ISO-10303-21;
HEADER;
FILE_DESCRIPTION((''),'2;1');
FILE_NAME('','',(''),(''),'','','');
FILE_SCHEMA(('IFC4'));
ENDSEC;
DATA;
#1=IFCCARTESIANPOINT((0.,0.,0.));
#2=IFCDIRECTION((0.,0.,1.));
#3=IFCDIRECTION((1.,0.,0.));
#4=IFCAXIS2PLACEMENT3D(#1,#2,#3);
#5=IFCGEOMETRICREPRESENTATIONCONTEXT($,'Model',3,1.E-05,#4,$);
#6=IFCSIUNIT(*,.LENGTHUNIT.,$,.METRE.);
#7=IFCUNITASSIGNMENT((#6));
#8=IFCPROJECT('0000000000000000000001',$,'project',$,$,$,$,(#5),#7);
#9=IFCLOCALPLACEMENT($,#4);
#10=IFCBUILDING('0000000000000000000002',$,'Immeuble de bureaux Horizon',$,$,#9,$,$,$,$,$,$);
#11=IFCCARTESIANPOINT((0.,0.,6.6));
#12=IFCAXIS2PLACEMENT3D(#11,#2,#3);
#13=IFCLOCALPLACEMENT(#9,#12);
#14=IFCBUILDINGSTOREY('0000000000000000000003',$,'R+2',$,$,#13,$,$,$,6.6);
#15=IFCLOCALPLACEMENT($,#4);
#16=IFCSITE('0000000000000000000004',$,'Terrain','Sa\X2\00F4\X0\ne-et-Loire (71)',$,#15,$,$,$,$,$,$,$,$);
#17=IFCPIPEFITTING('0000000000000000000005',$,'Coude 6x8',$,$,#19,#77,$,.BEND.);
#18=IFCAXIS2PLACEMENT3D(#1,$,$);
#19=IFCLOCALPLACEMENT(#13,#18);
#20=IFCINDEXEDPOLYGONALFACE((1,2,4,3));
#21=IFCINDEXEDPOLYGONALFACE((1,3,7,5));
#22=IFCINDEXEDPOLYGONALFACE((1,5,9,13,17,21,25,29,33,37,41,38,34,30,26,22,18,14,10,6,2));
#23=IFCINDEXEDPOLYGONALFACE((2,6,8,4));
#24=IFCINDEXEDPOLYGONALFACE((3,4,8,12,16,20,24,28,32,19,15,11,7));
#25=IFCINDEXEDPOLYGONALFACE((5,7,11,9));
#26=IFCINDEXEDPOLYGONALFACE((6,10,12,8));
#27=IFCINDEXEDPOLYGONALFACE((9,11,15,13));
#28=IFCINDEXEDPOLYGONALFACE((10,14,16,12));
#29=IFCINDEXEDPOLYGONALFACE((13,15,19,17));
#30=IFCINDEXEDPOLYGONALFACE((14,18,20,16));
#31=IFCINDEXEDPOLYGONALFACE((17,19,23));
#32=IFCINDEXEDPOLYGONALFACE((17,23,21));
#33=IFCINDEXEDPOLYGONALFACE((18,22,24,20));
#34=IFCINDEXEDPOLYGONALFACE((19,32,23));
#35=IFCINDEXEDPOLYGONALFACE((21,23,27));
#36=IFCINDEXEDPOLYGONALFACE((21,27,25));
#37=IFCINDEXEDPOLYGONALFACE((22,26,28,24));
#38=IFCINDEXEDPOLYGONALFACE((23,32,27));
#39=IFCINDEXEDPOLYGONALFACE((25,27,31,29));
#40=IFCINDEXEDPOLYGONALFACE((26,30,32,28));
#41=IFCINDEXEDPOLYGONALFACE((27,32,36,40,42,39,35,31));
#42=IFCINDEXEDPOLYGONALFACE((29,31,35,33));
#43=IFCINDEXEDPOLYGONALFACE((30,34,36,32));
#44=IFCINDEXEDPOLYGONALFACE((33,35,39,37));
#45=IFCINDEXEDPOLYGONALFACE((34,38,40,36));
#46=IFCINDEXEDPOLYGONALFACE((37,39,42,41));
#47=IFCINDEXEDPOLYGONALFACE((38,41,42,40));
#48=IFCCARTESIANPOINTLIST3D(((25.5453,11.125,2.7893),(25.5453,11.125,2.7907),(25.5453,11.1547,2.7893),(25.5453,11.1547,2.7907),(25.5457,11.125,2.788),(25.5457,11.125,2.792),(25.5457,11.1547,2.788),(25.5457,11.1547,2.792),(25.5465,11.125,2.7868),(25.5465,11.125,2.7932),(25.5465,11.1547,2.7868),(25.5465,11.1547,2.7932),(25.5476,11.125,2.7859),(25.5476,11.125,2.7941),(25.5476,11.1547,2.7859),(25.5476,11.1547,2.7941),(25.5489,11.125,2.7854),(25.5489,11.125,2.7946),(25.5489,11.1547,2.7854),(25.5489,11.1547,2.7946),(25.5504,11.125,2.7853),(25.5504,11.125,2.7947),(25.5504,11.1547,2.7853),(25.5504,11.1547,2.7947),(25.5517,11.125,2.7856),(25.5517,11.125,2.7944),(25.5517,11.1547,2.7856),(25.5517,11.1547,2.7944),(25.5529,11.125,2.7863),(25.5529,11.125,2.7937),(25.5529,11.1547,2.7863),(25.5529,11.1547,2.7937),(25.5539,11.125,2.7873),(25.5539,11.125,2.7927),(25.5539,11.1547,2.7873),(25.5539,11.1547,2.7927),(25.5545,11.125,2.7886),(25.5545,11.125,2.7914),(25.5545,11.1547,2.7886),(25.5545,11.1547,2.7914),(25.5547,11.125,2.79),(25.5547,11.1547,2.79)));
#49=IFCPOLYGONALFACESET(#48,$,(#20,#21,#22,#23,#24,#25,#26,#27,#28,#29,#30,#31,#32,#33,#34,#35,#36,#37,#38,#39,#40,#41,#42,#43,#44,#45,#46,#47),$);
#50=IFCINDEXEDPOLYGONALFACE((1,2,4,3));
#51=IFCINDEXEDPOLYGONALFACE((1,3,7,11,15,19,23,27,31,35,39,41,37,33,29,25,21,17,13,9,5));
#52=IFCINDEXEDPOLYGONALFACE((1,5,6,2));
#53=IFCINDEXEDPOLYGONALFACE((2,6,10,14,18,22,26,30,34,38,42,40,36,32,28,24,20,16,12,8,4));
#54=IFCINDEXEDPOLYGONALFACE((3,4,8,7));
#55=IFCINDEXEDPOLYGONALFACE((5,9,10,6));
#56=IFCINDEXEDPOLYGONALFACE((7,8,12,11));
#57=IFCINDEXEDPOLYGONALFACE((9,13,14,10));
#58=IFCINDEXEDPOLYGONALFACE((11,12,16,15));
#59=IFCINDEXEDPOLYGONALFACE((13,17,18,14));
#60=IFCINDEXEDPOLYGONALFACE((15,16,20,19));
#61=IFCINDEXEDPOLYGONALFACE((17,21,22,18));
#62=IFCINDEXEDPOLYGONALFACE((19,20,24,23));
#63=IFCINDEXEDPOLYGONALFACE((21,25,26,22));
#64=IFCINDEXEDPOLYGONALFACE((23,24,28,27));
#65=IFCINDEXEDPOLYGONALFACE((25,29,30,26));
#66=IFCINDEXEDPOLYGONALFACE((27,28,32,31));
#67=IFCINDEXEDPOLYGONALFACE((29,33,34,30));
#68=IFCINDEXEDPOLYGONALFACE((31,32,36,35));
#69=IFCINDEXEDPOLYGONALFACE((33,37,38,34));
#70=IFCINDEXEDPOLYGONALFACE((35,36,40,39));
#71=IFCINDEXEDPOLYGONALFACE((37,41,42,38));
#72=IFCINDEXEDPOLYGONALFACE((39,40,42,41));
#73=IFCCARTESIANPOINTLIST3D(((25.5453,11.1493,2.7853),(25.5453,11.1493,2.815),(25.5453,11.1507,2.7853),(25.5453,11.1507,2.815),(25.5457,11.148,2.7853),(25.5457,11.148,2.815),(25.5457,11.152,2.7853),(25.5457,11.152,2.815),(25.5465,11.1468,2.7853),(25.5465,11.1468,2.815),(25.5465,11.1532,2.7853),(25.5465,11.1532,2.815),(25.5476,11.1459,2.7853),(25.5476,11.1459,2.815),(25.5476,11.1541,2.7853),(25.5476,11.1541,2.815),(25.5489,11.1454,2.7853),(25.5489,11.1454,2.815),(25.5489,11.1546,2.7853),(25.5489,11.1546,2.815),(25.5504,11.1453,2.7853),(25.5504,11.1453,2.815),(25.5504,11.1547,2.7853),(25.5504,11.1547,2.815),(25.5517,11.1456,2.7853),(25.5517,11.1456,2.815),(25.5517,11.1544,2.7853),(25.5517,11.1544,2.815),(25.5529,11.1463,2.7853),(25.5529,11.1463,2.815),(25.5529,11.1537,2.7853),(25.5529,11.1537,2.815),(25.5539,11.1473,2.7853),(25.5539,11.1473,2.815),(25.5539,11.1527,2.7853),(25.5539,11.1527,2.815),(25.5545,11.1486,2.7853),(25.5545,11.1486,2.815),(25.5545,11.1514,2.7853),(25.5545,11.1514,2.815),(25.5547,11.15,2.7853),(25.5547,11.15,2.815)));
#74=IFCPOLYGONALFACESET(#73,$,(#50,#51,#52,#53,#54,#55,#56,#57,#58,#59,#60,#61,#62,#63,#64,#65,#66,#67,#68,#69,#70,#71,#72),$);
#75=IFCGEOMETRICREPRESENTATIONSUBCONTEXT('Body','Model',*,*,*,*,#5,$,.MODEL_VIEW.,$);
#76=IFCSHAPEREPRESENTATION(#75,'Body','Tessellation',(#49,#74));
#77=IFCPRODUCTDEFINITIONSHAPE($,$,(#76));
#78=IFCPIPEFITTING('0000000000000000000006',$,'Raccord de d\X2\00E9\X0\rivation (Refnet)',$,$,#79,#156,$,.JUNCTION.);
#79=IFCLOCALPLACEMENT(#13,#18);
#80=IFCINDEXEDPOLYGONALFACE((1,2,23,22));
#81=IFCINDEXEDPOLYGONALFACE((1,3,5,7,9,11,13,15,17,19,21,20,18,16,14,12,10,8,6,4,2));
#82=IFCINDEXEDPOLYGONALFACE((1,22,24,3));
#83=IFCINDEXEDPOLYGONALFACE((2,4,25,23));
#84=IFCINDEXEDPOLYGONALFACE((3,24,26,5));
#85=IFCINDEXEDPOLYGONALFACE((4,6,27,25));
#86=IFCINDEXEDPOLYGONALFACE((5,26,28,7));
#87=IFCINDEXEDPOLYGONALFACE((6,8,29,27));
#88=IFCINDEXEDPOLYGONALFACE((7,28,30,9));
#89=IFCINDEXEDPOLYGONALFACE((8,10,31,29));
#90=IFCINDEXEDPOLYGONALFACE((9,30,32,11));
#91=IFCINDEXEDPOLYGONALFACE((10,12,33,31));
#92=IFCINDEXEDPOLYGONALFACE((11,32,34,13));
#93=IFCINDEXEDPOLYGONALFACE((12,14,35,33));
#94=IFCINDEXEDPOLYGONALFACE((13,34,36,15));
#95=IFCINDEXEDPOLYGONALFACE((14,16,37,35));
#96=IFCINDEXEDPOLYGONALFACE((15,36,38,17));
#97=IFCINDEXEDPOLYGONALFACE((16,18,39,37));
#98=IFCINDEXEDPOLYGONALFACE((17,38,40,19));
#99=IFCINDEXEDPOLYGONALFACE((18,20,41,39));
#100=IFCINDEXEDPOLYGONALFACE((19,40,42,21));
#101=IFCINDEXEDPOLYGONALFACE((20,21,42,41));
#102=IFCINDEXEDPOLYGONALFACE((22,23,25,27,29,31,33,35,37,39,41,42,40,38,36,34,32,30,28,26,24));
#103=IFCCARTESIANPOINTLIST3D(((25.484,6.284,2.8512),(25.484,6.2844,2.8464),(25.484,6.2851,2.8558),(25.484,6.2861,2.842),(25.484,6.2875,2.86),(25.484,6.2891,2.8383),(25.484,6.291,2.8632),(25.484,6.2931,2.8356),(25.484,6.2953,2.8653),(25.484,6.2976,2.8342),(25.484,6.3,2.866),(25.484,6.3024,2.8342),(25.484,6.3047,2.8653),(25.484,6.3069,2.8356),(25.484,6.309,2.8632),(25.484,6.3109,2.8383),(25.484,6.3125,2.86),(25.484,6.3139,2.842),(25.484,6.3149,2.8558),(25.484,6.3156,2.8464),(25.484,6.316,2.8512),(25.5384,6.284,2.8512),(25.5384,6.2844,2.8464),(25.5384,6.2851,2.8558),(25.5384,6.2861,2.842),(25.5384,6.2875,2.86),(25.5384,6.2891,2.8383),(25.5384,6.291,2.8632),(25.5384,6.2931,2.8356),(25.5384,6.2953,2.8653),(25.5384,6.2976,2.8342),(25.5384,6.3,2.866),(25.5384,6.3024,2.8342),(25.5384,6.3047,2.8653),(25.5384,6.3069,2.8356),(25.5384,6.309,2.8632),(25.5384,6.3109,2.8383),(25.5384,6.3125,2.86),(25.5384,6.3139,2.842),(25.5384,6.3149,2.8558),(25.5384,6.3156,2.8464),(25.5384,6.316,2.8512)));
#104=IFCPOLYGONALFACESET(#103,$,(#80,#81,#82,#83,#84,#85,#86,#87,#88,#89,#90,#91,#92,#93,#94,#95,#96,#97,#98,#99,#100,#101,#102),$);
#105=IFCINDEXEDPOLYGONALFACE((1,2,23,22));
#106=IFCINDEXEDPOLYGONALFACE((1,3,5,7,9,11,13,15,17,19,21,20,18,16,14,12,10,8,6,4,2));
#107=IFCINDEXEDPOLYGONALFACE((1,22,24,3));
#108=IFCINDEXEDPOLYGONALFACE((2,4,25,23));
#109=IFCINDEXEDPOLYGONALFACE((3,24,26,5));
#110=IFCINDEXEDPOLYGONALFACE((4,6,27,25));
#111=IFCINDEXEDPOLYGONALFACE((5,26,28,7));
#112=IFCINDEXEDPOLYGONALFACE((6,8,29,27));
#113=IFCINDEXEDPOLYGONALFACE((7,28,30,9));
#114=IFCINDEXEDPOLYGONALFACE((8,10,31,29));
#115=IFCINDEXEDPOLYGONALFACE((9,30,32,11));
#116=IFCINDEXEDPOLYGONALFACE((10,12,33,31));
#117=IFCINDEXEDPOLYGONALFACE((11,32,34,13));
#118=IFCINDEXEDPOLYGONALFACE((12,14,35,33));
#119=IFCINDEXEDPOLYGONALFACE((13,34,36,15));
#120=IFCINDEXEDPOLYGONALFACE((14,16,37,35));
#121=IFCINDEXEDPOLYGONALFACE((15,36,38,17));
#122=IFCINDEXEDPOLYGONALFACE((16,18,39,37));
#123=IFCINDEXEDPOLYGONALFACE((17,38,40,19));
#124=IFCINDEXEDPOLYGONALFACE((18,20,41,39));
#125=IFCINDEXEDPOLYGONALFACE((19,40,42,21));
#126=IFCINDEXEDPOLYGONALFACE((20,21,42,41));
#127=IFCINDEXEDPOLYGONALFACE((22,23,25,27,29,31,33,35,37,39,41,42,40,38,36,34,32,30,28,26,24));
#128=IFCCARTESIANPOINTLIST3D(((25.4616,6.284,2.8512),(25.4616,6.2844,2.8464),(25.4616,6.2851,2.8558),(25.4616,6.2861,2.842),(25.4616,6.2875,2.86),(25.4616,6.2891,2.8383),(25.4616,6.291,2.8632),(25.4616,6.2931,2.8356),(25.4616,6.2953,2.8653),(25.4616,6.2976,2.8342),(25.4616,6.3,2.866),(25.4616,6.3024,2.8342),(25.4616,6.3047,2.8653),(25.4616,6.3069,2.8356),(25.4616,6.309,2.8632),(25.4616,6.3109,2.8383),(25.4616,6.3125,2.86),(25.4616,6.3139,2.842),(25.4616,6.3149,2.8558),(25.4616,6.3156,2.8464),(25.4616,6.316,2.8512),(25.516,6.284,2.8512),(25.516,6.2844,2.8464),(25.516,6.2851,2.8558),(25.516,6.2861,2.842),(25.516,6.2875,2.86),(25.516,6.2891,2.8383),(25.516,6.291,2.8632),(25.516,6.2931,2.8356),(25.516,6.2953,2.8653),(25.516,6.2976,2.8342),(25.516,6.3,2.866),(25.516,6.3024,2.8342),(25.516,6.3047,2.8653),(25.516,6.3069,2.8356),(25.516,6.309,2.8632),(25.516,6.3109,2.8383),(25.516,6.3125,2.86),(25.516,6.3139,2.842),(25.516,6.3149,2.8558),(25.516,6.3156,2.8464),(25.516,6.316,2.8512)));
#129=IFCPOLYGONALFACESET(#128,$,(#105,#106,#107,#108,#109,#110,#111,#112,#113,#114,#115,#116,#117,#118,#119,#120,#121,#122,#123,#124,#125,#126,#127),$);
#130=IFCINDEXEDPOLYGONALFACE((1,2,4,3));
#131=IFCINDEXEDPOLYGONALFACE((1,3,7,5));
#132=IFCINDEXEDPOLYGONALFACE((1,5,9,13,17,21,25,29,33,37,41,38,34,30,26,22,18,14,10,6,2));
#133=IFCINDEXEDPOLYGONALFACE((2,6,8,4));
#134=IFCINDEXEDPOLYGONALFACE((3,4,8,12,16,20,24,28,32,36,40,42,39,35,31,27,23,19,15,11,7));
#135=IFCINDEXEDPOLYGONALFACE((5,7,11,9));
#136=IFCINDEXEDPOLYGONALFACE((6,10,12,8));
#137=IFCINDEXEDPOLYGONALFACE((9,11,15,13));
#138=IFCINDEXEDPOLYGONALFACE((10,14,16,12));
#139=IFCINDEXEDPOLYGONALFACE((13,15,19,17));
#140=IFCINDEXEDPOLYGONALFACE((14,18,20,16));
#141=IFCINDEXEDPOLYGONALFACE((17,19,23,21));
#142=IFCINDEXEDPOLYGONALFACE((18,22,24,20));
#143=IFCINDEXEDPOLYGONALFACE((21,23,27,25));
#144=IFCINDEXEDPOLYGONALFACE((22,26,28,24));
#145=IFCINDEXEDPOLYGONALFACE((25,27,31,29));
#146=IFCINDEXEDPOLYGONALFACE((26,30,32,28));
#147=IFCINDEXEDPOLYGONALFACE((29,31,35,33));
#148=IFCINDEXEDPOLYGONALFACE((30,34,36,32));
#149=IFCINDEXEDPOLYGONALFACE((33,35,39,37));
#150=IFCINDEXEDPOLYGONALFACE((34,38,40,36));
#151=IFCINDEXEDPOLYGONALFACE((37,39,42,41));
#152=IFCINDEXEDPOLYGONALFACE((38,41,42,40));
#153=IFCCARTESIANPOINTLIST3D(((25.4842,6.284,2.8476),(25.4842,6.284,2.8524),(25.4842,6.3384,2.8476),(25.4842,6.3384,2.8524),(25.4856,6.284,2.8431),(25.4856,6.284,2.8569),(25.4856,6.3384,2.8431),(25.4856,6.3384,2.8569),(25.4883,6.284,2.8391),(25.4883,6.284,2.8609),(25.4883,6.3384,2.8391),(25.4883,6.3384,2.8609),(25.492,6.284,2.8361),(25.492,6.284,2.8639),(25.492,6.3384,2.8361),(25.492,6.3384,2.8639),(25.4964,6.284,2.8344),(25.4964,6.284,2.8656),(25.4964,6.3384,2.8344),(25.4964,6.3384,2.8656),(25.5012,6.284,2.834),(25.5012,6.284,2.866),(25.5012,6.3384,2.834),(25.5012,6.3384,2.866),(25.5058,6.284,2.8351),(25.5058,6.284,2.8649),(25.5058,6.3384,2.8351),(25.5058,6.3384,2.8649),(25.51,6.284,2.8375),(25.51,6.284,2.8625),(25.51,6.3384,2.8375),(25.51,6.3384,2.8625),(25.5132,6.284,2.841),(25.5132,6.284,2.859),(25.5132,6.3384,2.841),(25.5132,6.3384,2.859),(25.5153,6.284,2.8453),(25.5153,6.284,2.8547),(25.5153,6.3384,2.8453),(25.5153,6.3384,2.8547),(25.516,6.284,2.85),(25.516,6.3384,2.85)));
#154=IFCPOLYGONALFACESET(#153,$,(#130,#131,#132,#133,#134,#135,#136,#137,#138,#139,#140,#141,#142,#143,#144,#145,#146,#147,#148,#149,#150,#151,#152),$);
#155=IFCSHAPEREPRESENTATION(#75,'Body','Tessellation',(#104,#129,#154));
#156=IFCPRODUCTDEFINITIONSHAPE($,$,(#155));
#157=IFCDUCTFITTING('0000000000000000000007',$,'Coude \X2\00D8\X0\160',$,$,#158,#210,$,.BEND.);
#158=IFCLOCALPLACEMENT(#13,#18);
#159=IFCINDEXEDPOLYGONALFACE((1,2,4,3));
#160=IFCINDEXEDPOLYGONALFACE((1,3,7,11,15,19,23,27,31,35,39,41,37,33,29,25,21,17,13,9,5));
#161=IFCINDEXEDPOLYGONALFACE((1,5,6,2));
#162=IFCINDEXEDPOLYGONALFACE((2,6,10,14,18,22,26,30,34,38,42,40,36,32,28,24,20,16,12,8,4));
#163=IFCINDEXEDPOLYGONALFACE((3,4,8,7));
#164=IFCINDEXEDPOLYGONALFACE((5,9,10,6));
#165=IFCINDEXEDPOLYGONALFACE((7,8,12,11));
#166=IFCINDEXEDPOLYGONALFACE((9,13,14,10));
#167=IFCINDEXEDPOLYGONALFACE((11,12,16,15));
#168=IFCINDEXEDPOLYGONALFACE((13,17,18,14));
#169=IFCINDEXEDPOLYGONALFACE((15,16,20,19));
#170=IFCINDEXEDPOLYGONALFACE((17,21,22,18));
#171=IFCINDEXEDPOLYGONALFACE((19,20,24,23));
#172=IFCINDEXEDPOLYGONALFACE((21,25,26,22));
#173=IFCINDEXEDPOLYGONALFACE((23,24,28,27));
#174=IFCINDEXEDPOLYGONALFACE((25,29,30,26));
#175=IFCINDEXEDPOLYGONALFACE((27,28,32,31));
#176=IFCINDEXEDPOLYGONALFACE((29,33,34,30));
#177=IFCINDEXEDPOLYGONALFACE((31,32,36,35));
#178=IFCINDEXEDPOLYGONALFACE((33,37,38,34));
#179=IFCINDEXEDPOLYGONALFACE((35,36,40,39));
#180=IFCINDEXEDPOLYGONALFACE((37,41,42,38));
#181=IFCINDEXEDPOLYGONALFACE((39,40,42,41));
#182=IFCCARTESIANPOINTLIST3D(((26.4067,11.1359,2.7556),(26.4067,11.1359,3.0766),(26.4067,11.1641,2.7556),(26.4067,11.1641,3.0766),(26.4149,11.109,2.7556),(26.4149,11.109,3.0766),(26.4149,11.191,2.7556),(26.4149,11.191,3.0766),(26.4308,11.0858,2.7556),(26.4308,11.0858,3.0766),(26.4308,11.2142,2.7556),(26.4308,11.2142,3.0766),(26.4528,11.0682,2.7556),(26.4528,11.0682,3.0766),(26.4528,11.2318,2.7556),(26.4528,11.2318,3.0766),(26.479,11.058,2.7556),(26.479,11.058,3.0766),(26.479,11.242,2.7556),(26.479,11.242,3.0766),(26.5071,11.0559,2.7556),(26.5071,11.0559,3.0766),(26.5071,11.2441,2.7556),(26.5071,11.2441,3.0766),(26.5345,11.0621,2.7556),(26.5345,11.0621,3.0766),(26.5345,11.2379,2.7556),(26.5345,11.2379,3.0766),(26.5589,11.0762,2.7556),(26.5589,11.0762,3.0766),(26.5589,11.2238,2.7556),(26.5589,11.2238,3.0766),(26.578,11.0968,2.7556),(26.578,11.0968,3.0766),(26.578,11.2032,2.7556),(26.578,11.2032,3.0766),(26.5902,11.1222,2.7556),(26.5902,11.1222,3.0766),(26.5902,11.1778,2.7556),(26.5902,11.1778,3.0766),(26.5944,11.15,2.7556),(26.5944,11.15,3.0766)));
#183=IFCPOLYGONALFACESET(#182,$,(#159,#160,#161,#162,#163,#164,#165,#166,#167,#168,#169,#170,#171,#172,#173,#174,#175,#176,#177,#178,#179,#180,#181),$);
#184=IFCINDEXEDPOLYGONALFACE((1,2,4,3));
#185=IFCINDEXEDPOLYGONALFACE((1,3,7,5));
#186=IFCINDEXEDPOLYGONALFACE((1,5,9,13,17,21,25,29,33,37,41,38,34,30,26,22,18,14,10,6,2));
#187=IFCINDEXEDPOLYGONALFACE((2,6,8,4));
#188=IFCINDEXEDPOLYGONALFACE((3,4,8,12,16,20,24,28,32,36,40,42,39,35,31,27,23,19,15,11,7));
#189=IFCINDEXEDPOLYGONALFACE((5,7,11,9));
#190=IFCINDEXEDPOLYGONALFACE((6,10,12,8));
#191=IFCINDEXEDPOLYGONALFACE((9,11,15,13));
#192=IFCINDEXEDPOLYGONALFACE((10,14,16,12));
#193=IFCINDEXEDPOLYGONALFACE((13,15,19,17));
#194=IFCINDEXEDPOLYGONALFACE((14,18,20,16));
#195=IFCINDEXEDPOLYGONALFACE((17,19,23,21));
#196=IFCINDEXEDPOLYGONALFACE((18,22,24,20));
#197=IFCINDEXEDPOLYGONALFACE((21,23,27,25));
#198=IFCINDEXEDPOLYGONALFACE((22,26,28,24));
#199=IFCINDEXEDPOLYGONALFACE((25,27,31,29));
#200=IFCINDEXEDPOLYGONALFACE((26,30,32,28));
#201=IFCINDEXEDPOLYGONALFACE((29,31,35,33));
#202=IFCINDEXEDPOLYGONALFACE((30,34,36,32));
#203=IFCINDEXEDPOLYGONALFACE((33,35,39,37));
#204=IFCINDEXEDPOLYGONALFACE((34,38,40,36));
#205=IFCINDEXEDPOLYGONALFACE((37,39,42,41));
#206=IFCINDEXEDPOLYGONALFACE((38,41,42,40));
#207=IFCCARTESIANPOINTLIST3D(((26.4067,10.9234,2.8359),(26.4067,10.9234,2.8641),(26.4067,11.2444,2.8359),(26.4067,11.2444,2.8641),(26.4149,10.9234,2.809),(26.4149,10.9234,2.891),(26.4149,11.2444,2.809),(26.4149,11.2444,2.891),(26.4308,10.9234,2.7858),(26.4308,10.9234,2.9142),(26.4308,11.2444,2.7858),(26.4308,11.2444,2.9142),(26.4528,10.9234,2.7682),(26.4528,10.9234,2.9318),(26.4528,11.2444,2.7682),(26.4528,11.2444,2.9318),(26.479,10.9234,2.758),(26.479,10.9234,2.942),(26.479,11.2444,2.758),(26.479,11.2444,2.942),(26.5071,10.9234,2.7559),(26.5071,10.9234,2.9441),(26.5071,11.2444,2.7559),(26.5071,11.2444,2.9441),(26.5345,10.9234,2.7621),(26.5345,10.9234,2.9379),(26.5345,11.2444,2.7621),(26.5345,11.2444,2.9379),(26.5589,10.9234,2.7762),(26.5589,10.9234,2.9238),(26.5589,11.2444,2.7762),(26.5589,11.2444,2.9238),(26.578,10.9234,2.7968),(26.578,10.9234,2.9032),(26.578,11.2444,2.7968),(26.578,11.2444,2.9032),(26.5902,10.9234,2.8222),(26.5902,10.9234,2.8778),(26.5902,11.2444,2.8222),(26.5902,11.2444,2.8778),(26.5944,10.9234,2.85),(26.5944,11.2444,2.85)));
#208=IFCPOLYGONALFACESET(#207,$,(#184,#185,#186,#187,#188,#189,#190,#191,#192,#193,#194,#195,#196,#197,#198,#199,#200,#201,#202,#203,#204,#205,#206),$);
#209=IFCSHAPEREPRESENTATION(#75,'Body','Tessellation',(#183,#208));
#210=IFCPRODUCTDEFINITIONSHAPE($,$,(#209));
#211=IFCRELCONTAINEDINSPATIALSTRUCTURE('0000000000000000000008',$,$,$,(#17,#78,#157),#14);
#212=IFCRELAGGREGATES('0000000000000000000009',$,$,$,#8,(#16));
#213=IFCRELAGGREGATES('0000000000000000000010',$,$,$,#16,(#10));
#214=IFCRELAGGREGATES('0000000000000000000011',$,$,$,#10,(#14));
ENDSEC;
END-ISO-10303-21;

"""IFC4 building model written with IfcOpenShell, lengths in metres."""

from ifc_helpers import new_model, si_unit, frame, origin_with_axes, place, context, subcontext, project, spatial, circle, extrude, element, save


model = new_model("IFC4")

# Units and contexts
model_context = context("Model", 3, precision=1e-05, world=origin_with_axes())
body_context = subcontext(model_context, "Body", "Model", "MODEL_VIEW")
ifc_project = project(units=[si_unit("LENGTHUNIT", "METRE")], contexts=[model_context])

# Site, building, storey
site_placement = place(None, origin_with_axes())
site = spatial("IfcSite", under=ifc_project, at=site_placement, Name="Terrain", Description="Saône-et-Loire (71)")
building_placement = place(None, origin_with_axes())
building = spatial("IfcBuilding", under=site, at=building_placement, Name="Immeuble de bureaux Horizon")
storey_placement = place(building_placement, frame((0.0, 0.0, 6.6), z_axis=(0.0, 0.0, 1.0), x_axis=(1.0, 0.0, 0.0)))
storey = spatial("IfcBuildingStorey", under=building, at=storey_placement, Name="R+2", Elevation=6.6)

# Pipe fittings
pipe_fitting_1_placement = place(storey_placement, frame((25.55, 11.15, 2.79), z_axis=(0.0, 0.0, 1.0), x_axis=(1.0, 0.0, 0.0)))
element("IfcPipeFitting", 1, at=pipe_fitting_1_placement, inside=storey, Name="Coude 6x8", PredefinedType="BEND", context=body_context, shape_type="SweptSolid", body=[
    extrude(circle(Radius=0.0047), frame((0.0, 0.0047, 0.0), z_axis=(0.0, -1.0, 0.0), x_axis=(1.0, 0.0, 0.0)), (0.0, 0.0, 1.0), 0.0297),
    extrude(circle(Radius=0.0047), frame((0.0, 0.0, -0.0047), z_axis=(0.0, 0.0, 1.0), x_axis=(1.0, 0.0, 0.0)), (0.0, 0.0, 1.0), 0.0297),
])
pipe_fitting_2_placement = place(storey_placement, frame((25.5, 6.3, 2.85), z_axis=(0.0, 0.0, 1.0), x_axis=(1.0, 0.0, 0.0)))
element("IfcPipeFitting", 2, at=pipe_fitting_2_placement, inside=storey, Name="Raccord de dérivation (Refnet)", PredefinedType="JUNCTION", context=body_context, shape_type="SweptSolid", body=[
    extrude(circle(Radius=0.016), frame((-0.016, 0.0, 0.0), z_axis=(1.0, 0.0, 0.0), x_axis=(0.0, 0.0, 1.0)), (0.0, 0.0, 1.0), 0.0544),
    extrude(circle(Radius=0.016), frame((0.016, 0.0, 0.0), z_axis=(-1.0, 0.0, 0.0), x_axis=(0.0, 0.0, 1.0)), (0.0, 0.0, 1.0), 0.0544),
    extrude(circle(Radius=0.016), frame((0.0, -0.016, 0.0), z_axis=(0.0, 1.0, 0.0), x_axis=(1.0, 0.0, 0.0)), (0.0, 0.0, 1.0), 0.0544),
])

# Duct fitting
duct_fitting_1_placement = place(storey_placement, frame((26.5, 11.15, 2.85), z_axis=(0.0, 0.0, 1.0), x_axis=(1.0, 0.0, 0.0)))
element("IfcDuctFitting", 3, at=duct_fitting_1_placement, inside=storey, Name="Coude Ø160", PredefinedType="BEND", context=body_context, shape_type="SweptSolid", body=[
    extrude(circle(Radius=0.0944), frame((0.0, 0.0, -0.0944), z_axis=(0.0, 0.0, 1.0), x_axis=(1.0, 0.0, 0.0)), (0.0, 0.0, 1.0), 0.321),
    extrude(circle(Radius=0.0944), frame((0.0, 0.0944, 0.0), z_axis=(0.0, -1.0, 0.0), x_axis=(1.0, 0.0, 0.0)), (0.0, 0.0, 1.0), 0.321),
])

save(model, "model.ifc")
